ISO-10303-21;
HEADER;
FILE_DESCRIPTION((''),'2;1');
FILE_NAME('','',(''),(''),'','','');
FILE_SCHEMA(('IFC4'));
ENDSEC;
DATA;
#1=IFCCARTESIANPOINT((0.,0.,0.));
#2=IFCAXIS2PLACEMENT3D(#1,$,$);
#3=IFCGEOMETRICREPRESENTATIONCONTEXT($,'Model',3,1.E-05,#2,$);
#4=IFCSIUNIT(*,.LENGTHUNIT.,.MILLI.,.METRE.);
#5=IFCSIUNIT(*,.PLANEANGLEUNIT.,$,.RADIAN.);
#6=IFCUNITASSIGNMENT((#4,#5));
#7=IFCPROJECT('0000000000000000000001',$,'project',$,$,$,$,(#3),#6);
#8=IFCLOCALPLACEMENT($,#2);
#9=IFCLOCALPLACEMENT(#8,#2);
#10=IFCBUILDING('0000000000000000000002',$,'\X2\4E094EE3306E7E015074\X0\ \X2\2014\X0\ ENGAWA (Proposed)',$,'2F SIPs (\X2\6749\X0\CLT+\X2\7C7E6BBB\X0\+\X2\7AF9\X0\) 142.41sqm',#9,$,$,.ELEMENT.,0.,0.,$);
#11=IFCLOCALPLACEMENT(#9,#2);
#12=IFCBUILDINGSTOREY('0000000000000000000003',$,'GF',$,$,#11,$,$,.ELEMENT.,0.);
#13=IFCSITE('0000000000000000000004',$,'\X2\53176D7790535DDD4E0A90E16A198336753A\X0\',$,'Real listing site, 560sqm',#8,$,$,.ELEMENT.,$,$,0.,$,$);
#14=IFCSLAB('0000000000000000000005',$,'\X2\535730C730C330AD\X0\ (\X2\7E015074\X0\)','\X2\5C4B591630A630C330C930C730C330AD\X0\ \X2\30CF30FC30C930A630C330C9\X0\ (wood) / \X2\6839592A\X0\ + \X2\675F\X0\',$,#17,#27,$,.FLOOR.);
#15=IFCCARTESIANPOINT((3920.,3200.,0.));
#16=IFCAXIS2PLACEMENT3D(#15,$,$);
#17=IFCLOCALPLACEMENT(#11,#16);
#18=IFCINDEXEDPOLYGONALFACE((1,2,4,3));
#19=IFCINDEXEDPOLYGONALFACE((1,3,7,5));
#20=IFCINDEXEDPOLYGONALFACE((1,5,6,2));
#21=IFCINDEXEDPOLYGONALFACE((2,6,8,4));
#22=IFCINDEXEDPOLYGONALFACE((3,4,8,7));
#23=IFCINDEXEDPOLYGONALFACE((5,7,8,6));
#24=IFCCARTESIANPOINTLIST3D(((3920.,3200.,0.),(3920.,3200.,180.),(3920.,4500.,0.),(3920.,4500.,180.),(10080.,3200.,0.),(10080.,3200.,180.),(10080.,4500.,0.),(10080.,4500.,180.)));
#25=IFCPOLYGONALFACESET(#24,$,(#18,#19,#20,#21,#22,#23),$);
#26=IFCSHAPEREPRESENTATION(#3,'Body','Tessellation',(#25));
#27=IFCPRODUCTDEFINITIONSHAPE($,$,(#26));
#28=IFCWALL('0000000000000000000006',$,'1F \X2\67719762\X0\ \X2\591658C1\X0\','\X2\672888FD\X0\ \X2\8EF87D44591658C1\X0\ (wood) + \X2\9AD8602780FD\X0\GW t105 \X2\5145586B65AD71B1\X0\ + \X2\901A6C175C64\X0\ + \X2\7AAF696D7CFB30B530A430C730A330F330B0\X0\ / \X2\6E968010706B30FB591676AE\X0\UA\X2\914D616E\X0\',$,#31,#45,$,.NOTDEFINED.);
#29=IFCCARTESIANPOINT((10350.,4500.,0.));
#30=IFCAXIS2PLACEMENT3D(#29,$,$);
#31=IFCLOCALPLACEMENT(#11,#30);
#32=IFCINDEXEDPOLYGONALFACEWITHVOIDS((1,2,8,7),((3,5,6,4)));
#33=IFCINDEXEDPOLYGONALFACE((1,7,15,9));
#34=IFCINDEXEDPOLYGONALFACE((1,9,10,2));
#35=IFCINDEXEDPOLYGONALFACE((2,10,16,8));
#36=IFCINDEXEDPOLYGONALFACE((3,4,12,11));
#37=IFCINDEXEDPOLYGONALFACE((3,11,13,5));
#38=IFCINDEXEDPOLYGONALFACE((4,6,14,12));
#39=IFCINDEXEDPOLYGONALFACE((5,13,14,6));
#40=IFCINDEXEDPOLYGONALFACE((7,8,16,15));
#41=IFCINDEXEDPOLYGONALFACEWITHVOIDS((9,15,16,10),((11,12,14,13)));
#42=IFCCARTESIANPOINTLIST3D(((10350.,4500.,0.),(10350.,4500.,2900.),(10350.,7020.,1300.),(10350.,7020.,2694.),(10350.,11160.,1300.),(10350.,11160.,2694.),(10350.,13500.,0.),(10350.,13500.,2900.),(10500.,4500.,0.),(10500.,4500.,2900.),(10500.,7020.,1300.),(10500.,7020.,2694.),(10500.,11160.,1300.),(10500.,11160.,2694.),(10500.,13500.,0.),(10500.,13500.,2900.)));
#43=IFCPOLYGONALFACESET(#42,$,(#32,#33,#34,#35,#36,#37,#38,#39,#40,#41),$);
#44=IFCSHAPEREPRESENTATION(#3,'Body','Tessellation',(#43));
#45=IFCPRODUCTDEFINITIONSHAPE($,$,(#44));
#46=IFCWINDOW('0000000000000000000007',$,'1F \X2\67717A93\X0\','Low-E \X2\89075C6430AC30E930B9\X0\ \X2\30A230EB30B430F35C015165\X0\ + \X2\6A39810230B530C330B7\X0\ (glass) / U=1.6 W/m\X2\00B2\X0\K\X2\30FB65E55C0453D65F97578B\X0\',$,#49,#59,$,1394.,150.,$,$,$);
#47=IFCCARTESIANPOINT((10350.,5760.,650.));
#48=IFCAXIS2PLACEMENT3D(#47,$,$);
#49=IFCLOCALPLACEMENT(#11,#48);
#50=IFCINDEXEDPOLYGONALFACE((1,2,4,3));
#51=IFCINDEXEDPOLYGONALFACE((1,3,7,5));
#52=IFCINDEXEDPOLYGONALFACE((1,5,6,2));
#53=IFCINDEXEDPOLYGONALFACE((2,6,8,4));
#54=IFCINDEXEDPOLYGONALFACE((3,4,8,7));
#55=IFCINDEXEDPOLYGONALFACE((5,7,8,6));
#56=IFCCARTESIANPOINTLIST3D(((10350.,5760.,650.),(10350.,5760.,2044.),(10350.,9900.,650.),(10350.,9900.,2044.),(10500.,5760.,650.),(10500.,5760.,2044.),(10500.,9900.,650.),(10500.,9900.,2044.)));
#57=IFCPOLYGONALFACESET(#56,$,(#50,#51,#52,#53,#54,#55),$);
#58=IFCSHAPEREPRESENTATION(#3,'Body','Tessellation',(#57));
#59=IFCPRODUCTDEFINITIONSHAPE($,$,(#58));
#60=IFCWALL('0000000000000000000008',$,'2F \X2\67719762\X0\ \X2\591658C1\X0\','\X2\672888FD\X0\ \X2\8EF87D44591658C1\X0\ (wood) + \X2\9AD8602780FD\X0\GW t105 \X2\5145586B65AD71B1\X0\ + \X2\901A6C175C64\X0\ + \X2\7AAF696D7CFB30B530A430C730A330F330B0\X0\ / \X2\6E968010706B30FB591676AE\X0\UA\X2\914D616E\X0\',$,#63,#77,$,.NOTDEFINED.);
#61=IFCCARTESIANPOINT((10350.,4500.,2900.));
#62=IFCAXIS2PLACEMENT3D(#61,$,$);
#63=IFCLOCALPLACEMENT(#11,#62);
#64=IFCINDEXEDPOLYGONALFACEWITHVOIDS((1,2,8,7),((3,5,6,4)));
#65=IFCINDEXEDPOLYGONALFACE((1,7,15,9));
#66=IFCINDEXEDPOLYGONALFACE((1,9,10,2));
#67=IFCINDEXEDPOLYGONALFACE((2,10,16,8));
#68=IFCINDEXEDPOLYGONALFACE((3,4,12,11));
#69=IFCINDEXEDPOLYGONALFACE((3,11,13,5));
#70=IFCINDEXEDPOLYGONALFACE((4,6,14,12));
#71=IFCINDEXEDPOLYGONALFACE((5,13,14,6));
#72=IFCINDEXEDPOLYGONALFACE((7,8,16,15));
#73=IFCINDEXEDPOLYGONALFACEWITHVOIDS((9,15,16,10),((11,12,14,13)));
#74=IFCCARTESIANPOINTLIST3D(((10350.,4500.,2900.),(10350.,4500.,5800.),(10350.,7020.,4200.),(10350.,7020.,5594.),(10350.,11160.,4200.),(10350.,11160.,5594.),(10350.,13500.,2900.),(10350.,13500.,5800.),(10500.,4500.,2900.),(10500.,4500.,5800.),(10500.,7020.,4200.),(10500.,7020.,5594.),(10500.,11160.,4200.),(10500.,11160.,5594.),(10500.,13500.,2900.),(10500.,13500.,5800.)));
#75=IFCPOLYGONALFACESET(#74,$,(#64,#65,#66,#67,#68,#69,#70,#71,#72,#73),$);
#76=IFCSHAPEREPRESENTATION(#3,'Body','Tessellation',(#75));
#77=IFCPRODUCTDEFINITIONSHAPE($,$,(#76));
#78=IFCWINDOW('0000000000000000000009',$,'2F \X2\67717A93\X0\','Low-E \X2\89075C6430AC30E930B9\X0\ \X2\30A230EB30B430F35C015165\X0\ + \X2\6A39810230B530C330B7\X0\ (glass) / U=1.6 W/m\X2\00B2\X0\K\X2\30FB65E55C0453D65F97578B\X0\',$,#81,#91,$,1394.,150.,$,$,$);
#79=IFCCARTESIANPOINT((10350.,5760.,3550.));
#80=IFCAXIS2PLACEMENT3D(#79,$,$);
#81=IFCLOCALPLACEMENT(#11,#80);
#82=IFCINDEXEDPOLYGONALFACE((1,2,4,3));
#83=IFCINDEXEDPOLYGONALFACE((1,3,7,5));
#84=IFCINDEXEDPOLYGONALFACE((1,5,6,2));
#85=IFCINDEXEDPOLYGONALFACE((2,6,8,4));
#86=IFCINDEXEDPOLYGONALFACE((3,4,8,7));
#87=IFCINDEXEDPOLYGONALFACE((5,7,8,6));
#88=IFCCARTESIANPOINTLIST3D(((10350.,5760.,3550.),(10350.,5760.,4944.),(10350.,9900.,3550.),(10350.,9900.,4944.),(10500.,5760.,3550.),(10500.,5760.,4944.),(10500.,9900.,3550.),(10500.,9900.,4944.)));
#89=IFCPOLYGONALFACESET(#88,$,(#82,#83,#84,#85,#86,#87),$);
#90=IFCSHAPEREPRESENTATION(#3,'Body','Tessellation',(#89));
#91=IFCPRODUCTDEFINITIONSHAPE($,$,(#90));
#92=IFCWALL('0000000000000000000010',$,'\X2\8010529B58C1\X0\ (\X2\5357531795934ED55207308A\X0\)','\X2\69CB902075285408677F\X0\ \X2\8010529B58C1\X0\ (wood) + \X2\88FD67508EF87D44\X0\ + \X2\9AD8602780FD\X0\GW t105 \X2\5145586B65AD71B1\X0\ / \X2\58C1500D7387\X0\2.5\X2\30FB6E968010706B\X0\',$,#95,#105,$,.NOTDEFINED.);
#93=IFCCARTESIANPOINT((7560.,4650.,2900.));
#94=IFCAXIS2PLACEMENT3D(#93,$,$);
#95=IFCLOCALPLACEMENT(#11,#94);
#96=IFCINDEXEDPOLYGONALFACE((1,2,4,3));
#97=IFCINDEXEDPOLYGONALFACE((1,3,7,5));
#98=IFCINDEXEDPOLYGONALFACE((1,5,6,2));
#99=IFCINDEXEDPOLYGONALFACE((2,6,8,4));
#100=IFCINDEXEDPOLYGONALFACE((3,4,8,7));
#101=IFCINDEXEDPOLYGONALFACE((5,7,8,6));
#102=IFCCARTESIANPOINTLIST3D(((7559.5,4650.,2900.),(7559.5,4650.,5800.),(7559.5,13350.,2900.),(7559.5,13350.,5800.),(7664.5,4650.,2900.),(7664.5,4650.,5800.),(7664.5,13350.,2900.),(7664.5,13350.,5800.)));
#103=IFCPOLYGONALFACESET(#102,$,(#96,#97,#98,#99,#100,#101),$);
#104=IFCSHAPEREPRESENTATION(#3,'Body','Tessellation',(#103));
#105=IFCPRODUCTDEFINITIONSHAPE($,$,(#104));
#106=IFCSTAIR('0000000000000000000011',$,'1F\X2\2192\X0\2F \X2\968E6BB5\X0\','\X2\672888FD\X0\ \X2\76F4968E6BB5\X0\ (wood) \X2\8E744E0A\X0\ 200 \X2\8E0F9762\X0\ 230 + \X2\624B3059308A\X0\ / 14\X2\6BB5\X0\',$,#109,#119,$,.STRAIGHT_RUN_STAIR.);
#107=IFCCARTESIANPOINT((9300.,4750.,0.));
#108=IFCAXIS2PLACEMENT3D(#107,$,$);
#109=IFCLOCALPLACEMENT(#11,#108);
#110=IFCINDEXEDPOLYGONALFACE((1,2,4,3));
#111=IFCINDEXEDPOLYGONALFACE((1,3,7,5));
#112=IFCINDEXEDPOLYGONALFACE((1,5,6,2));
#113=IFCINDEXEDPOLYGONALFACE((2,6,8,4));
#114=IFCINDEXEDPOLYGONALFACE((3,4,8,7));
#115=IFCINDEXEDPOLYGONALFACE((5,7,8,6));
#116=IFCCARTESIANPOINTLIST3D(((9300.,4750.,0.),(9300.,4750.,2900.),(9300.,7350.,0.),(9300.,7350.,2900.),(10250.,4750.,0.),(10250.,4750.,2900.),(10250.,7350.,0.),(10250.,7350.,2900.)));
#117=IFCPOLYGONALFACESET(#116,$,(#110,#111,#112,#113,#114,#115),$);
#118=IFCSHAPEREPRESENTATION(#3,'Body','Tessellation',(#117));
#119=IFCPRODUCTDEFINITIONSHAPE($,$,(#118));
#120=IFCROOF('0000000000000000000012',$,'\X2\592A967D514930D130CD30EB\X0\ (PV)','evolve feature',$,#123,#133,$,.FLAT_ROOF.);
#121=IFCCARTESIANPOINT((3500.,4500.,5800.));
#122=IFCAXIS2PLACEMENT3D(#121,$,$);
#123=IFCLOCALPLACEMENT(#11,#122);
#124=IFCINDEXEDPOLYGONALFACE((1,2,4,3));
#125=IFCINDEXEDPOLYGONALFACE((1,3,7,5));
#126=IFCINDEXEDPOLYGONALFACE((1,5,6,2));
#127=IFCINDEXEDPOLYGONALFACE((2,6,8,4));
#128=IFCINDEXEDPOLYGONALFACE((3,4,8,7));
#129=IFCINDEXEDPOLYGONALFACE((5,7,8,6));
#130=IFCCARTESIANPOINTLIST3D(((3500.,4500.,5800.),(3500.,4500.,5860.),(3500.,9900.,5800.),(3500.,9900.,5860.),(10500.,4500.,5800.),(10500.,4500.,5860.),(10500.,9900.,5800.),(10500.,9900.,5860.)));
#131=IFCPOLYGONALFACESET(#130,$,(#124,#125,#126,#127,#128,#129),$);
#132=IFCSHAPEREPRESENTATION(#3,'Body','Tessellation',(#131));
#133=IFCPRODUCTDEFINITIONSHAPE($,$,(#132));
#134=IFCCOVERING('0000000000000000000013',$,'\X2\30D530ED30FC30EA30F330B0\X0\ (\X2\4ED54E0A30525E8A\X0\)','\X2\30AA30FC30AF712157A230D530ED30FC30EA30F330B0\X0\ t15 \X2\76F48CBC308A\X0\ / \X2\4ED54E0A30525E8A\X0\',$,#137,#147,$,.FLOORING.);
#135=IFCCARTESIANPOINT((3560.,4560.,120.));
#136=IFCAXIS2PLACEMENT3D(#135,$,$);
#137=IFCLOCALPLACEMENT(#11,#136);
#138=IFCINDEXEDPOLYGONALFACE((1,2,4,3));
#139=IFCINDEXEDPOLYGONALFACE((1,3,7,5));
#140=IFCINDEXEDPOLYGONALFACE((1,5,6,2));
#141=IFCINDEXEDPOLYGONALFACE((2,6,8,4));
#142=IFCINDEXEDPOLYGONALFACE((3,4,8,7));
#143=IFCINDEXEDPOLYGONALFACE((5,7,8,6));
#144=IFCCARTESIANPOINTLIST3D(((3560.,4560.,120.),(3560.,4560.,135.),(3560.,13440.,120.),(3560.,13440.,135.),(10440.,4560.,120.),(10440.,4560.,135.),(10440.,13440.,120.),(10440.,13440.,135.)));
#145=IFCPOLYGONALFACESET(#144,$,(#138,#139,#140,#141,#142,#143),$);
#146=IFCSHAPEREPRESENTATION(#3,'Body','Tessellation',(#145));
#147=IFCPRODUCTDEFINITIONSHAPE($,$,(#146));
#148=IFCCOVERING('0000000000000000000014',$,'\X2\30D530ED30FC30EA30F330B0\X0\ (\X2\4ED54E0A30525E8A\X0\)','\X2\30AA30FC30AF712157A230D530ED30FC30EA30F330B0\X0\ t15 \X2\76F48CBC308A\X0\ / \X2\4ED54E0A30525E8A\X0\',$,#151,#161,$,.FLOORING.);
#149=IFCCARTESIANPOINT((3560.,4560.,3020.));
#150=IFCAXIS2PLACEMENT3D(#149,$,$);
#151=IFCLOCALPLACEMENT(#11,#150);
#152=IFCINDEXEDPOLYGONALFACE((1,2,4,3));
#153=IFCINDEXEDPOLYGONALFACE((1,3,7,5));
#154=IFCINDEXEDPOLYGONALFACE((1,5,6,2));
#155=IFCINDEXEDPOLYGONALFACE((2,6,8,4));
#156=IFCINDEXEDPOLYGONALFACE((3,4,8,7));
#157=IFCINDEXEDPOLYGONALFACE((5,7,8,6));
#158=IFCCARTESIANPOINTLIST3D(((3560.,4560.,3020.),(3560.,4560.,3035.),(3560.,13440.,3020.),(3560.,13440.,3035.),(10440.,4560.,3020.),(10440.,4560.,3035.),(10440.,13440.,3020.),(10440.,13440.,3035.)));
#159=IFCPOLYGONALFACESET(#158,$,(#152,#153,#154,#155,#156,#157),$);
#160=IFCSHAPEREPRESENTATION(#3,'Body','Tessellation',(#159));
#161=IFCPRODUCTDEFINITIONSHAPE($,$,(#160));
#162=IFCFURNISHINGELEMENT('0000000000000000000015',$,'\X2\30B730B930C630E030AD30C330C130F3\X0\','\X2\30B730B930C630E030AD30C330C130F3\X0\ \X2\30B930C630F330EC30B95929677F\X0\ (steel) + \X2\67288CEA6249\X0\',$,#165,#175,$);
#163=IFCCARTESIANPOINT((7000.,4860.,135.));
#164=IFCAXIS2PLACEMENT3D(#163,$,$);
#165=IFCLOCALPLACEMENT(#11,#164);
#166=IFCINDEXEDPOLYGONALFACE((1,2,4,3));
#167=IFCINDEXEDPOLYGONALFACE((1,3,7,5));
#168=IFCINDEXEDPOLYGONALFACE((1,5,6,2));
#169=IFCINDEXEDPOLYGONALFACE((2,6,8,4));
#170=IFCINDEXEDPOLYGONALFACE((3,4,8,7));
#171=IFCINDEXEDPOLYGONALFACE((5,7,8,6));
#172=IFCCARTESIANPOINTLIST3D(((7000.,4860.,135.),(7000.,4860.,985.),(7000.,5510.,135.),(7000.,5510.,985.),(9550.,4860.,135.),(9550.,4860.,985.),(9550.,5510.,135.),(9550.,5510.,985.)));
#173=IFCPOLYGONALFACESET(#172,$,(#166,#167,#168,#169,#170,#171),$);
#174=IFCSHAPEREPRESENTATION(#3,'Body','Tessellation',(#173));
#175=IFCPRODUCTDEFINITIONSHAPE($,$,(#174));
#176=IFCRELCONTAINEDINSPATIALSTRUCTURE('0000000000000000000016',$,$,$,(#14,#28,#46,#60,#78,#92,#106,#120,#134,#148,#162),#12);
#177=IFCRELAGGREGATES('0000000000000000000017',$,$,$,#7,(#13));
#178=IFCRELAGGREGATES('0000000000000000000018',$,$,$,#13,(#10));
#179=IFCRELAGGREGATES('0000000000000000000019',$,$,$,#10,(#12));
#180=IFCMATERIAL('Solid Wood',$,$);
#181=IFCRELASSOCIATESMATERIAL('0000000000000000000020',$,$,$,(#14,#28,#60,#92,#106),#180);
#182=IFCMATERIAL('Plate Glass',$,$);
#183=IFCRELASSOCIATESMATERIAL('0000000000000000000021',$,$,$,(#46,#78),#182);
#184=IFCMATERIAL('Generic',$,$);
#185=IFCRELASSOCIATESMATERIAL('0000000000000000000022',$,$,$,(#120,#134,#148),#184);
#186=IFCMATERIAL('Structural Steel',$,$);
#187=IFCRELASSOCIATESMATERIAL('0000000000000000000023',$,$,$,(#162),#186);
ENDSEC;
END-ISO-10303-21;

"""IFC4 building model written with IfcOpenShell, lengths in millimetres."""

from ifc_helpers import new_model, si_unit, frame, frame_2d, origin, place, context, project, spatial, rectangle, extrude, material, element, fill, save


model = new_model("IFC4")

# Units and contexts
model_context = context("Model", 3, precision=1e-05, world=origin())
ifc_project = project(units=[si_unit("LENGTHUNIT", "METRE", prefix="MILLI"), si_unit("PLANEANGLEUNIT", "RADIAN")], contexts=[model_context])

# Site, building, storey
site_placement = place(None, origin())
site = spatial("IfcSite", under=ifc_project, at=site_placement, Name="北海道川上郡標茶町", ObjectType="Real listing site, 560sqm", CompositionType="ELEMENT", RefElevation=0.0)
building_placement = place(site_placement, origin())
building = spatial("IfcBuilding", under=site, at=building_placement, Name="三代の縁側 — ENGAWA (Proposed)", ObjectType="2F SIPs (杉CLT+籾殻+竹) 142.41sqm", CompositionType="ELEMENT", ElevationOfRefHeight=0.0, ElevationOfTerrain=0.0)
storey_placement = place(building_placement, origin())
storey = spatial("IfcBuildingStorey", under=building, at=storey_placement, Name="GF", CompositionType="ELEMENT", Elevation=0.0)

# Slab
ifc_material_1 = material(Name="Solid Wood")
slab_placement = place(storey_placement, frame((3920.0, 3200.0, 0.0)))
element("IfcSlab", 1, at=slab_placement, inside=storey, material=ifc_material_1, Name="南デッキ (縁側)", Description="屋外ウッドデッキ ハードウッド (wood) / 根太 + 束", PredefinedType="FLOOR", context=model_context, shape_type="SweptSolid", body=[
    extrude(rectangle(XDim=6160.0, YDim=1300.0, at=frame_2d((3080.0, 650.0))), frame((3920.0, 3200.0, 0.0)), (0.0, 0.0, 1.0), 180.0),
])

# Wall, opening, window
wall_1_placement = place(storey_placement, frame((10350.0, 4500.0, 0.0)))
wall_1 = element("IfcWall", 2, at=wall_1_placement, inside=storey, material=ifc_material_1, Name="1F 東面 外壁", Description="木製 軸組外壁 (wood) + 高性能GW t105 充填断熱 + 通気層 + 窯業系サイディング / 準耐火・外皮UA配慮", PredefinedType="NOTDEFINED", context=model_context, shape_type="SweptSolid", body=[
    extrude(rectangle(XDim=150.0, YDim=9000.0, at=frame_2d((75.0, 4500.0))), frame((10350.0, 4500.0, 0.0)), (0.0, 0.0, 1.0), 2900.0),
])
opening_1_placement = place(storey_placement, frame((10350.0, 5760.0, 650.0)))
opening_1 = element("IfcOpeningElement", 3, at=opening_1_placement, cuts=wall_1, PredefinedType="NOTDEFINED", context=model_context, shape_type="SweptSolid", body=[
    extrude(rectangle(XDim=150.0, YDim=4140.0, at=frame_2d((75.0, 2070.0))), frame((10350.0, 5760.0, 650.0)), (0.0, 0.0, 1.0), 1394.0),
])
ifc_material_2 = material(Name="Plate Glass")
window_1_placement = place(storey_placement, frame((10350.0, 5760.0, 650.0)))
window_1 = element("IfcWindow", 4, at=window_1_placement, inside=storey, material=ifc_material_2, Name="1F 東窓", Description="Low-E 複層ガラス アルゴン封入 + 樹脂サッシ (glass) / U=1.6 W/m²K・日射取得型", OverallHeight=1394.0, OverallWidth=150.0, context=model_context, shape_type="SweptSolid", body=[
    extrude(rectangle(XDim=150.0, YDim=4140.0, at=frame_2d((75.0, 2070.0))), frame((10350.0, 5760.0, 650.0)), (0.0, 0.0, 1.0), 1394.0),
])
fill(opening_1, window_1)

# Wall, opening, window
wall_2_placement = place(storey_placement, frame((10350.0, 4500.0, 2900.0)))
wall_2 = element("IfcWall", 5, at=wall_2_placement, inside=storey, material=ifc_material_1, Name="2F 東面 外壁", Description="木製 軸組外壁 (wood) + 高性能GW t105 充填断熱 + 通気層 + 窯業系サイディング / 準耐火・外皮UA配慮", PredefinedType="NOTDEFINED", context=model_context, shape_type="SweptSolid", body=[
    extrude(rectangle(XDim=150.0, YDim=9000.0, at=frame_2d((75.0, 4500.0))), frame((10350.0, 4500.0, 2900.0)), (0.0, 0.0, 1.0), 2900.0),
])
opening_2_placement = place(storey_placement, frame((10350.0, 5760.0, 3550.0)))
opening_2 = element("IfcOpeningElement", 6, at=opening_2_placement, cuts=wall_2, PredefinedType="NOTDEFINED", context=model_context, shape_type="SweptSolid", body=[
    extrude(rectangle(XDim=150.0, YDim=4140.0, at=frame_2d((75.0, 2070.0))), frame((10350.0, 5760.0, 3550.0)), (0.0, 0.0, 1.0), 1394.0),
])
window_2_placement = place(storey_placement, frame((10350.0, 5760.0, 3550.0)))
window_2 = element("IfcWindow", 7, at=window_2_placement, inside=storey, material=ifc_material_2, Name="2F 東窓", Description="Low-E 複層ガラス アルゴン封入 + 樹脂サッシ (glass) / U=1.6 W/m²K・日射取得型", OverallHeight=1394.0, OverallWidth=150.0, context=model_context, shape_type="SweptSolid", body=[
    extrude(rectangle(XDim=150.0, YDim=4140.0, at=frame_2d((75.0, 2070.0))), frame((10350.0, 5760.0, 3550.0)), (0.0, 0.0, 1.0), 1394.0),
])
fill(opening_2, window_2)

# Wall
wall_3_placement = place(storey_placement, frame((7560.0, 4650.0, 2900.0)))
element("IfcWall", 8, at=wall_3_placement, inside=storey, material=ifc_material_1, Name="耐力壁 (南北間仕切り)", Description="構造用合板 耐力壁 (wood) + 製材軸組 + 高性能GW t105 充填断熱 / 壁倍率2.5・準耐火", PredefinedType="NOTDEFINED", context=model_context, shape_type="SweptSolid", body=[
    extrude(rectangle(XDim=105.0, YDim=8700.0, at=frame_2d((52.0, 4350.0))), frame((7560.0, 4650.0, 2900.0)), (0.0, 0.0, 1.0), 2900.0),
])

# Stair
stair_placement = place(storey_placement, frame((9300.0, 4750.0, 0.0)))
element("IfcStair", 9, at=stair_placement, inside=storey, material=ifc_material_1, Name="1F→2F 階段", Description="木製 直階段 (wood) 蹴上 200 踏面 230 + 手すり / 14段", PredefinedType="STRAIGHT_RUN_STAIR", context=model_context, shape_type="SweptSolid", body=[
    extrude(rectangle(XDim=950.0, YDim=2600.0, at=frame_2d((475.0, 1300.0))), frame((9300.0, 4750.0, 0.0)), (0.0, 0.0, 1.0), 2900.0),
])

# Roof
ifc_material_3 = material(Name="Generic")
roof_placement = place(storey_placement, frame((3500.0, 4500.0, 5800.0)))
element("IfcRoof", 10, at=roof_placement, inside=storey, material=ifc_material_3, Name="太陽光パネル (PV)", Description="evolve feature", PredefinedType="FLAT_ROOF", context=model_context, shape_type="SweptSolid", body=[
    extrude(rectangle(XDim=7000.0, YDim=5400.0, at=frame_2d((3500.0, 2700.0))), frame((3500.0, 4500.0, 5800.0)), (0.0, 0.0, 1.0), 60.0),
])

# Coverings
covering_1_placement = place(storey_placement, frame((3560.0, 4560.0, 120.0)))
element("IfcCovering", 11, at=covering_1_placement, inside=storey, material=ifc_material_3, Name="フローリング (仕上げ床)", Description="オーク無垢フローリング t15 直貼り / 仕上げ床", PredefinedType="FLOORING", context=model_context, shape_type="SweptSolid", body=[
    extrude(rectangle(XDim=6880.0, YDim=8880.0, at=frame_2d((3440.0, 4440.0))), frame((3560.0, 4560.0, 120.0)), (0.0, 0.0, 1.0), 15.0),
])
covering_2_placement = place(storey_placement, frame((3560.0, 4560.0, 3020.0)))
element("IfcCovering", 12, at=covering_2_placement, inside=storey, material=ifc_material_3, Name="フローリング (仕上げ床)", Description="オーク無垢フローリング t15 直貼り / 仕上げ床", PredefinedType="FLOORING", context=model_context, shape_type="SweptSolid", body=[
    extrude(rectangle(XDim=6880.0, YDim=8880.0, at=frame_2d((3440.0, 4440.0))), frame((3560.0, 4560.0, 3020.0)), (0.0, 0.0, 1.0), 15.0),
])

# Furnishing element
ifc_material_4 = material(Name="Structural Steel")
furnishing_placement = place(storey_placement, frame((7000.0, 4860.0, 135.0)))
element("IfcFurnishingElement", 13, at=furnishing_placement, inside=storey, material=ifc_material_4, Name="システムキッチン", Description="システムキッチン ステンレス天板 (steel) + 木質扉", context=model_context, shape_type="SweptSolid", body=[
    extrude(rectangle(XDim=2550.0, YDim=650.0, at=frame_2d((1275.0, 325.0))), frame((7000.0, 4860.0, 135.0)), (0.0, 0.0, 1.0), 850.0),
])

save(model, "model.ifc")
